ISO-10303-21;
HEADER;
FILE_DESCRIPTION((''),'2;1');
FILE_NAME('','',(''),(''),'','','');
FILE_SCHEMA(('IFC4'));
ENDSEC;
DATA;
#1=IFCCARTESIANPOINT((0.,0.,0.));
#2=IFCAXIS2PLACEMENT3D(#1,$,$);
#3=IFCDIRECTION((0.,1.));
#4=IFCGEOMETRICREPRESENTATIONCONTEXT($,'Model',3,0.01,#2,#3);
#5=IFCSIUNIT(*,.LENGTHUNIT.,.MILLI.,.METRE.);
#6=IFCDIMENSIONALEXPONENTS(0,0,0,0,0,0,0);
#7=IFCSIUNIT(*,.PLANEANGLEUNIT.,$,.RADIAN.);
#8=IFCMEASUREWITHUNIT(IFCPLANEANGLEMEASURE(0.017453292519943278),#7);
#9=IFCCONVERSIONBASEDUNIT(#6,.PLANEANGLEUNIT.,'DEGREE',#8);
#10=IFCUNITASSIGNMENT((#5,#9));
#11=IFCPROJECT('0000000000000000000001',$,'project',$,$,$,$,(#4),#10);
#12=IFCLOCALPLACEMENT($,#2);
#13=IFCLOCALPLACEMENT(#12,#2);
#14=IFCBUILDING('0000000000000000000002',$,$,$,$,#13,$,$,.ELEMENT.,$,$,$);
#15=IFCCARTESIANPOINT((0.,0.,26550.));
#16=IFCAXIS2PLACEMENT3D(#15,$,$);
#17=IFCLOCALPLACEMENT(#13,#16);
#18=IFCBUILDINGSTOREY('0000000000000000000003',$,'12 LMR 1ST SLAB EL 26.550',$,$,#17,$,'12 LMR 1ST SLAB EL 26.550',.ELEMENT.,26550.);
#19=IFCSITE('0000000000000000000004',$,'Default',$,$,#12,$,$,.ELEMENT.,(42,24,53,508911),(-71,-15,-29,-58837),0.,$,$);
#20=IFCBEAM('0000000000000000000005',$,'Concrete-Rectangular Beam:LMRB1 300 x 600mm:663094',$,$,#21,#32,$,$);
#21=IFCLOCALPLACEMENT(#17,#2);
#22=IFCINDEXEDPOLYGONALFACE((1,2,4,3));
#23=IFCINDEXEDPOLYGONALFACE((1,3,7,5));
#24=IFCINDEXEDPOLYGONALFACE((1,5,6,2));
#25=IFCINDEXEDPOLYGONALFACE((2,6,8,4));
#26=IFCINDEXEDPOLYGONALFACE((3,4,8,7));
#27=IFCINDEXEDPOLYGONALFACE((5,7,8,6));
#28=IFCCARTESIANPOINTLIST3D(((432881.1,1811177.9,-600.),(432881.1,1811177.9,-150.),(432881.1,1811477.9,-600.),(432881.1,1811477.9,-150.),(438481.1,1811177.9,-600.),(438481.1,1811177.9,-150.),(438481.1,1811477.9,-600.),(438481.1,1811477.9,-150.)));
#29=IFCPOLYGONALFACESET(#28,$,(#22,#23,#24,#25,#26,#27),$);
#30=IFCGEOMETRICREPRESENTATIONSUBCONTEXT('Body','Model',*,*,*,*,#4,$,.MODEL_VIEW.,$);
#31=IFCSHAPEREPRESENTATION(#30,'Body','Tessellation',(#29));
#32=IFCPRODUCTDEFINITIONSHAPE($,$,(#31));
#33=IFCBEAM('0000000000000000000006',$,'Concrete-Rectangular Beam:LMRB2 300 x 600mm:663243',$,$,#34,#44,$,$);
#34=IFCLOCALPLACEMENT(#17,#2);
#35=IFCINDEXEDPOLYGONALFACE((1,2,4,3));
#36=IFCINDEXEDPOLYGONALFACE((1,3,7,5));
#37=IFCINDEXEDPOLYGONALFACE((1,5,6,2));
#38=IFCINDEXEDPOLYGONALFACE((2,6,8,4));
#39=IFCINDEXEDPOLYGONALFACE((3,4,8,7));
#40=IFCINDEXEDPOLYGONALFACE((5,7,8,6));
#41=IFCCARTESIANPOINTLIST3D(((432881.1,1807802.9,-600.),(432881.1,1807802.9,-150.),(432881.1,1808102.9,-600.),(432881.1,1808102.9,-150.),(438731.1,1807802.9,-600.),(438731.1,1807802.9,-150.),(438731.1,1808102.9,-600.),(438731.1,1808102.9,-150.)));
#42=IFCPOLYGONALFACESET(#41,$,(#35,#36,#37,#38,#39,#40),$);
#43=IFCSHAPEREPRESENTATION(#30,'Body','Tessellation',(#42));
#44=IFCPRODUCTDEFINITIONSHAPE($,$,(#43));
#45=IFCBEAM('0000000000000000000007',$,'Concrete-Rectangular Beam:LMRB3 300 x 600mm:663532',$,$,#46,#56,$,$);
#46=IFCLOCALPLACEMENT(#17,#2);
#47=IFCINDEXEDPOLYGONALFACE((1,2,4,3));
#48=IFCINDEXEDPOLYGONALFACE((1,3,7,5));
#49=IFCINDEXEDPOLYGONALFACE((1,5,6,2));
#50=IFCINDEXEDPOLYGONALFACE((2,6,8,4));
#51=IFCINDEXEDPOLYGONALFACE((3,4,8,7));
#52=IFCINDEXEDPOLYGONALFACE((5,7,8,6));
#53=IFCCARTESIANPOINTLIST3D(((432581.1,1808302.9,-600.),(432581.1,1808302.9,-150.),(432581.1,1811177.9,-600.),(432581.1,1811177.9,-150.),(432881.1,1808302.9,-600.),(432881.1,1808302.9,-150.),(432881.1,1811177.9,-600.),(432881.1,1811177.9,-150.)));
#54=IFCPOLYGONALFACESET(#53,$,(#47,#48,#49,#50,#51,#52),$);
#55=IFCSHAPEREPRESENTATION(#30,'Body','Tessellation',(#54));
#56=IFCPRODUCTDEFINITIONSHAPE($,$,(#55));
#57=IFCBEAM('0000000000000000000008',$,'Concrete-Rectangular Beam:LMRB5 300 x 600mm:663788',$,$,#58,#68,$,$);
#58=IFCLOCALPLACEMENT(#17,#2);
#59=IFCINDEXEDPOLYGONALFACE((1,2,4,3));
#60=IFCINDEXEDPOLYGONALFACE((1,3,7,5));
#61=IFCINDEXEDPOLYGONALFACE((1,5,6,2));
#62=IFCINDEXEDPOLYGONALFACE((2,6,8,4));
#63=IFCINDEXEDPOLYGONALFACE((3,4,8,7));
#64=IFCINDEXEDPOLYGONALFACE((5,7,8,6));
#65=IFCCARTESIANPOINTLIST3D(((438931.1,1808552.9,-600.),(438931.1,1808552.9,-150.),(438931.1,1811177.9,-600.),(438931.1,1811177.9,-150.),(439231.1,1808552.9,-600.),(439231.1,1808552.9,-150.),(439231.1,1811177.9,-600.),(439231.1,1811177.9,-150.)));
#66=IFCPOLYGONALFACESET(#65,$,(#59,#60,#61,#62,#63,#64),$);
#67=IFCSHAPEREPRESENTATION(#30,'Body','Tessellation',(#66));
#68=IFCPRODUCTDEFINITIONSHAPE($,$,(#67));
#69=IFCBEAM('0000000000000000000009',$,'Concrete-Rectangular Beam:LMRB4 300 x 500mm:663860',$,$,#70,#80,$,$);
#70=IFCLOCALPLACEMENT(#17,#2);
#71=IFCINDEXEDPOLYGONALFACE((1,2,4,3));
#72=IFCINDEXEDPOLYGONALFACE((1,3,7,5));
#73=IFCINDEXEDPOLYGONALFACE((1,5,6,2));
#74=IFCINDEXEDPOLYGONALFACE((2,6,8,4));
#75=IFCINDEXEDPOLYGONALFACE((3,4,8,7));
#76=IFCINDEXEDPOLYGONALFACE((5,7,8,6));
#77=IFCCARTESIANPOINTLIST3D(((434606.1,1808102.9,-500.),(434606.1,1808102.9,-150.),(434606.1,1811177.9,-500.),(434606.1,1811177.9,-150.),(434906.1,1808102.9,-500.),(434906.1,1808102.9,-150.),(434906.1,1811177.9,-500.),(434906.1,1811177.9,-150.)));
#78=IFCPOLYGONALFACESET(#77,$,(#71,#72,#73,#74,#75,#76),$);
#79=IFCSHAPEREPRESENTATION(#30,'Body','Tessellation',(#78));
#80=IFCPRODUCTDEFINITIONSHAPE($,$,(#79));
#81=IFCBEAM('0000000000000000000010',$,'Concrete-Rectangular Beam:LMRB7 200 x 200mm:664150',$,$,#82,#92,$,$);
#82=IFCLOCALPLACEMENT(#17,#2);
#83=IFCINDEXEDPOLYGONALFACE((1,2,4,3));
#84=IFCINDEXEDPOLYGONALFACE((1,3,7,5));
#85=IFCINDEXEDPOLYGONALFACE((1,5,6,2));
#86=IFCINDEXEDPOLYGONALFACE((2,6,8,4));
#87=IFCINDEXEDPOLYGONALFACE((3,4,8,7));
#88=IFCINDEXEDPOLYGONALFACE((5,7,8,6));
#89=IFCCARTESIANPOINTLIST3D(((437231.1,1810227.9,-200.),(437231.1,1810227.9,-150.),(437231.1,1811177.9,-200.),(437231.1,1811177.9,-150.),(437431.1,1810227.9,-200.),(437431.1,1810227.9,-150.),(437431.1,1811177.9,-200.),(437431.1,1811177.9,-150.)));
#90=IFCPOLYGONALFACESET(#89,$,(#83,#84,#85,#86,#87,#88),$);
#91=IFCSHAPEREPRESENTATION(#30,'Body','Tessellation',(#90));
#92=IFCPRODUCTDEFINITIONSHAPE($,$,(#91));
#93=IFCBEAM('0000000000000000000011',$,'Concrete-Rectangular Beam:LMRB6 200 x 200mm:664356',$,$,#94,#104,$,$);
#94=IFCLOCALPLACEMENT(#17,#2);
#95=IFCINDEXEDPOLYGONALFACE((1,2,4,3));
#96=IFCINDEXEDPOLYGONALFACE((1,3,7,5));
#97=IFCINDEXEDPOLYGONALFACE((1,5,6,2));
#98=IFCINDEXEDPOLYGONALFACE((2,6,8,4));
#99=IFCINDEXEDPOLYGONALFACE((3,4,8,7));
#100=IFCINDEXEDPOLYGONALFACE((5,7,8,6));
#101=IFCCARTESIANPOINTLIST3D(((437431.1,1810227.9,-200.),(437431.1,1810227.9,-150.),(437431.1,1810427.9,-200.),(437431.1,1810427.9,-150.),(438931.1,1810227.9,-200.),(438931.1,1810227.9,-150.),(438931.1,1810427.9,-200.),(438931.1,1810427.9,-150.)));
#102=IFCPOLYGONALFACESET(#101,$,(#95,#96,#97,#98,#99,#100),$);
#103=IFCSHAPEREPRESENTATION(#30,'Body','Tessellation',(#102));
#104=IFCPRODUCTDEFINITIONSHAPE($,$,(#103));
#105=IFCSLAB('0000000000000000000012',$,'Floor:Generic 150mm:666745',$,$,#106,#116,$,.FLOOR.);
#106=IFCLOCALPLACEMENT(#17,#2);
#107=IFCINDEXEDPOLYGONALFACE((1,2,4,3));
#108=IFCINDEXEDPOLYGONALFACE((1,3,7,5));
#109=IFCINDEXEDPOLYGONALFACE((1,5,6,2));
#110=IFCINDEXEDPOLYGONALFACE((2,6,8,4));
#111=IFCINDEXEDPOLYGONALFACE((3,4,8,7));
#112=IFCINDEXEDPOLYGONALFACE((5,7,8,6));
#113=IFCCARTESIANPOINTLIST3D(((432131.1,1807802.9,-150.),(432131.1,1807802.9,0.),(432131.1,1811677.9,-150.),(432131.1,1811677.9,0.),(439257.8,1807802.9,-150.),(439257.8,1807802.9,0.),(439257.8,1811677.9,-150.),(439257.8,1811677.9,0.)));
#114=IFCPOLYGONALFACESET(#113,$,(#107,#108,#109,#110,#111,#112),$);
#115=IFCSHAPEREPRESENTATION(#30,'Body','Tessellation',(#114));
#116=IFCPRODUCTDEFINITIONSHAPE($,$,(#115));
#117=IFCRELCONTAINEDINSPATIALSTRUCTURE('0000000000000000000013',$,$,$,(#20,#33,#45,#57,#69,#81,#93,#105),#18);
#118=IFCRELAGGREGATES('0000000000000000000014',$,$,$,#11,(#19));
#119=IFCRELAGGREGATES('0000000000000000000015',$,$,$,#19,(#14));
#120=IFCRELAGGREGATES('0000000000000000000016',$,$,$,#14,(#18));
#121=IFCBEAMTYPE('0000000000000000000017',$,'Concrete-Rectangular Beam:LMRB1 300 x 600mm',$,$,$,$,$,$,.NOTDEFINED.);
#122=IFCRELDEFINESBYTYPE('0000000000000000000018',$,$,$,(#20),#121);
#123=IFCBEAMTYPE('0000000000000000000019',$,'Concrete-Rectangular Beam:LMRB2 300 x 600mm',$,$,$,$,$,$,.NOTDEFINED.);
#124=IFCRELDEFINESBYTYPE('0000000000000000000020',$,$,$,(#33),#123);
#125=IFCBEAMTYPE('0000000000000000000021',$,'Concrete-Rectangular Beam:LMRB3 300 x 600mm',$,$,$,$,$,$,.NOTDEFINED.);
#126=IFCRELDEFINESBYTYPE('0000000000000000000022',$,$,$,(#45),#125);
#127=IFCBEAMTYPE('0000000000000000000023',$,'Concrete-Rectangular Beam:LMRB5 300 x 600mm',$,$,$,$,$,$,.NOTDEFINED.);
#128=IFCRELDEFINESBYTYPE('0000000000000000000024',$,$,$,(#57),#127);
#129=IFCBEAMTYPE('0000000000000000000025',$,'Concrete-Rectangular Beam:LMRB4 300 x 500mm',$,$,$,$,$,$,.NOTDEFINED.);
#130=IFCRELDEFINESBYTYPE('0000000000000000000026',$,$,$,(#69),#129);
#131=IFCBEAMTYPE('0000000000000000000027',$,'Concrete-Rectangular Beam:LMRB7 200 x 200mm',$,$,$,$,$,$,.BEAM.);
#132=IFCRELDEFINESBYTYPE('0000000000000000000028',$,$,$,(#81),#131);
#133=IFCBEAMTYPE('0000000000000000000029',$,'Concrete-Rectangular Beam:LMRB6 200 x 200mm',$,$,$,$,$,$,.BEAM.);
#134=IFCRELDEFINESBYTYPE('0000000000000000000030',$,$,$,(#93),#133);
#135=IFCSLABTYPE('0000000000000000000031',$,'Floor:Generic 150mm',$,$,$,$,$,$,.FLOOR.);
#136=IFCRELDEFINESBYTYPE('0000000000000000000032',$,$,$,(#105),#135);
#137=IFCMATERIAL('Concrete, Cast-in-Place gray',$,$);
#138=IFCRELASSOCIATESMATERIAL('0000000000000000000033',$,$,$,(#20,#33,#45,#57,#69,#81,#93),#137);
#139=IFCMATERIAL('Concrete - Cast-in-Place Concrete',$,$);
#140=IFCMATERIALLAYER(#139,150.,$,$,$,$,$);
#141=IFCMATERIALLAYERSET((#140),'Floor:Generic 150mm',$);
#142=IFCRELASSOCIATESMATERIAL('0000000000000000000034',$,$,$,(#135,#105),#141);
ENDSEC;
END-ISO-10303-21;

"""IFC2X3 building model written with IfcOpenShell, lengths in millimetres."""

from ifc_helpers import new_model, entity, si_unit, converted_unit, direction, frame, frame_2d, origin, origin_2d_with_axis, place, context, subcontext, project, spatial, rectangle, extrude, material, layer, layer_set, layer_usage, type_object, element, save


model = new_model("IFC2X3")

# Units and contexts
model_context = context("Model", 3, precision=0.01, world=origin(), true_north=direction((0.0, 1.0)))
body_context = subcontext(model_context, "Body", "Model", "MODEL_VIEW")
ifc_project = project(units=[si_unit("LENGTHUNIT", "METRE", prefix="MILLI"), converted_unit("PLANEANGLEUNIT", "DEGREE", entity("IfcPlaneAngleMeasure", 0.017453292519943278), si_unit("PLANEANGLEUNIT", "RADIAN"), dimensions=[0, 0, 0, 0, 0, 0, 0])], contexts=[model_context])

# Site, building, storey
site_placement = place(None, origin())
site = spatial("IfcSite", under=ifc_project, at=site_placement, Name="Default", CompositionType="ELEMENT", RefLatitude=(42, 24, 53, 508911), RefLongitude=(-71, -15, -29, -58837), RefElevation=0.0)
building_placement = place(site_placement, origin())
building = spatial("IfcBuilding", under=site, at=building_placement, CompositionType="ELEMENT")
storey_placement = place(building_placement, frame((0.0, 0.0, 26550.0)))
storey = spatial("IfcBuildingStorey", under=building, at=storey_placement, Name="12 LMR 1ST SLAB EL 26.550", LongName="12 LMR 1ST SLAB EL 26.550", CompositionType="ELEMENT", Elevation=26550.0)

# Beams
ifc_material_1 = material(Name="Concrete, Cast-in-Place gray")
beam_type_1 = type_object("IfcBeamType", Name="Concrete-Rectangular Beam:LMRB1 300 x 600mm", PredefinedType="NOTDEFINED")
beam_1_placement = place(storey_placement, frame((432881.1, 1811177.9, 0.0)))
element("IfcBeam", 1, at=beam_1_placement, inside=storey, type_object=beam_type_1, material=ifc_material_1, Name="Concrete-Rectangular Beam:LMRB1 300 x 600mm:663094", context=body_context, shape_type="SweptSolid", body=[
    extrude(rectangle(XDim=450.0, YDim=300.0, at=origin_2d_with_axis()), frame((0.0, 150.0, -375.0), z_axis=(1.0, 0.0, 0.0), x_axis=(0.0, 0.0, -1.0)), (0.0, 0.0, 1.0), 5600.0),
])
beam_type_2 = type_object("IfcBeamType", Name="Concrete-Rectangular Beam:LMRB2 300 x 600mm", PredefinedType="NOTDEFINED")
beam_2_placement = place(storey_placement, frame((432881.1, 1807802.9, 0.0)))
element("IfcBeam", 2, at=beam_2_placement, inside=storey, type_object=beam_type_2, material=ifc_material_1, Name="Concrete-Rectangular Beam:LMRB2 300 x 600mm:663243", context=body_context, shape_type="SweptSolid", body=[
    extrude(rectangle(XDim=450.0, YDim=300.0, at=origin_2d_with_axis()), frame((0.0, 150.0, -375.0), z_axis=(1.0, 0.0, 0.0), x_axis=(0.0, 0.0, -1.0)), (0.0, 0.0, 1.0), 5850.0),
])
beam_type_3 = type_object("IfcBeamType", Name="Concrete-Rectangular Beam:LMRB3 300 x 600mm", PredefinedType="NOTDEFINED")
beam_3_placement = place(storey_placement, frame((432881.1, 1808302.9, 0.0), z_axis=(0.0, 0.0, 1.0), x_axis=(0.0, 1.0, 0.0)))
element("IfcBeam", 3, at=beam_3_placement, inside=storey, type_object=beam_type_3, material=ifc_material_1, Name="Concrete-Rectangular Beam:LMRB3 300 x 600mm:663532", context=body_context, shape_type="SweptSolid", body=[
    extrude(rectangle(XDim=450.0, YDim=300.0, at=origin_2d_with_axis()), frame((0.0, 150.0, -375.0), z_axis=(1.0, 0.0, 0.0), x_axis=(0.0, 0.0, -1.0)), (0.0, 0.0, 1.0), 2875.0),
])
beam_type_4 = type_object("IfcBeamType", Name="Concrete-Rectangular Beam:LMRB5 300 x 600mm", PredefinedType="NOTDEFINED")
beam_4_placement = place(storey_placement, frame((439231.1, 1808552.9, 0.0), z_axis=(0.0, 0.0, 1.0), x_axis=(0.0, 1.0, 0.0)))
element("IfcBeam", 4, at=beam_4_placement, inside=storey, type_object=beam_type_4, material=ifc_material_1, Name="Concrete-Rectangular Beam:LMRB5 300 x 600mm:663788", context=body_context, shape_type="SweptSolid", body=[
    extrude(rectangle(XDim=450.0, YDim=300.0, at=origin_2d_with_axis()), frame((0.0, 150.0, -375.0), z_axis=(1.0, 0.0, 0.0), x_axis=(0.0, 0.0, -1.0)), (0.0, 0.0, 1.0), 2625.0),
])
beam_type_5 = type_object("IfcBeamType", Name="Concrete-Rectangular Beam:LMRB4 300 x 500mm", PredefinedType="NOTDEFINED")
beam_5_placement = place(storey_placement, frame((434906.1, 1808097.9, 0.0), z_axis=(0.0, 0.0, 1.0), x_axis=(0.0, 1.0, 0.0)))
element("IfcBeam", 5, at=beam_5_placement, inside=storey, type_object=beam_type_5, material=ifc_material_1, Name="Concrete-Rectangular Beam:LMRB4 300 x 500mm:663860", context=body_context, shape_type="SweptSolid", body=[
    extrude(rectangle(XDim=350.0, YDim=300.0, at=origin_2d_with_axis()), frame((5.0, 150.0, -325.0), z_axis=(1.0, 0.0, 0.0), x_axis=(0.0, 0.0, -1.0)), (0.0, 0.0, 1.0), 3075.0),
])
beam_type_6 = type_object("IfcBeamType", Name="Concrete-Rectangular Beam:LMRB7 200 x 200mm", PredefinedType="BEAM")
beam_6_placement = place(storey_placement, frame((437231.1, 1811177.9, 0.0), z_axis=(0.0, 0.0, 1.0), x_axis=(0.0, -1.0, 0.0)))
element("IfcBeam", 6, at=beam_6_placement, inside=storey, type_object=beam_type_6, material=ifc_material_1, Name="Concrete-Rectangular Beam:LMRB7 200 x 200mm:664150", context=body_context, shape_type="SweptSolid", body=[
    extrude(rectangle(XDim=50.0, YDim=200.0, at=frame_2d((0.0, 0.0), x_axis=(1.0, 0.0))), frame((0.0, 100.0, -175.0), z_axis=(1.0, 0.0, 0.0), x_axis=(0.0, 0.0, -1.0)), (0.0, 0.0, 1.0), 950.0),
])
beam_type_7 = type_object("IfcBeamType", Name="Concrete-Rectangular Beam:LMRB6 200 x 200mm", PredefinedType="BEAM")
beam_7_placement = place(storey_placement, frame((438931.1, 1810427.9, 0.0), z_axis=(0.0, 0.0, 1.0), x_axis=(-1.0, 0.0, 0.0)))
element("IfcBeam", 7, at=beam_7_placement, inside=storey, type_object=beam_type_7, material=ifc_material_1, Name="Concrete-Rectangular Beam:LMRB6 200 x 200mm:664356", context=body_context, shape_type="SweptSolid", body=[
    extrude(rectangle(XDim=50.0, YDim=200.0, at=frame_2d((0.0, 0.0), x_axis=(1.0, 0.0))), frame((0.0, 100.0, -175.0), z_axis=(1.0, 0.0, 0.0), x_axis=(0.0, 0.0, -1.0)), (0.0, 0.0, 1.0), 1500.0),
])

# Slab
ifc_material_2 = material(Name="Concrete - Cast-in-Place Concrete")
ifc_layer = layer(ifc_material_2, 150.0)
ifc_layer_set = layer_set([ifc_layer], Name="Floor:Generic 150mm")
ifc_layer_usage = layer_usage(ifc_layer_set, "AXIS3", "POSITIVE", 0.0)
slab_type = type_object("IfcSlabType", Name="Floor:Generic 150mm", PredefinedType="FLOOR", material=ifc_layer_set)
slab_placement = place(storey_placement, origin())
element("IfcSlab", 8, at=slab_placement, inside=storey, type_object=slab_type, material=ifc_layer_usage, Name="Floor:Generic 150mm:666745", PredefinedType="FLOOR", context=body_context, shape_type="SweptSolid", body=[
    extrude(rectangle(XDim=3875.0, YDim=7126.7, at=frame_2d((0.0, 0.0), x_axis=(1.0, 0.0))), frame((435694.5, 1809740.4, 0.0), z_axis=(0.0, 0.0, -1.0), x_axis=(0.0, 1.0, 0.0)), (0.0, 0.0, 1.0), 150.0),
])

save(model, "model.ifc")
